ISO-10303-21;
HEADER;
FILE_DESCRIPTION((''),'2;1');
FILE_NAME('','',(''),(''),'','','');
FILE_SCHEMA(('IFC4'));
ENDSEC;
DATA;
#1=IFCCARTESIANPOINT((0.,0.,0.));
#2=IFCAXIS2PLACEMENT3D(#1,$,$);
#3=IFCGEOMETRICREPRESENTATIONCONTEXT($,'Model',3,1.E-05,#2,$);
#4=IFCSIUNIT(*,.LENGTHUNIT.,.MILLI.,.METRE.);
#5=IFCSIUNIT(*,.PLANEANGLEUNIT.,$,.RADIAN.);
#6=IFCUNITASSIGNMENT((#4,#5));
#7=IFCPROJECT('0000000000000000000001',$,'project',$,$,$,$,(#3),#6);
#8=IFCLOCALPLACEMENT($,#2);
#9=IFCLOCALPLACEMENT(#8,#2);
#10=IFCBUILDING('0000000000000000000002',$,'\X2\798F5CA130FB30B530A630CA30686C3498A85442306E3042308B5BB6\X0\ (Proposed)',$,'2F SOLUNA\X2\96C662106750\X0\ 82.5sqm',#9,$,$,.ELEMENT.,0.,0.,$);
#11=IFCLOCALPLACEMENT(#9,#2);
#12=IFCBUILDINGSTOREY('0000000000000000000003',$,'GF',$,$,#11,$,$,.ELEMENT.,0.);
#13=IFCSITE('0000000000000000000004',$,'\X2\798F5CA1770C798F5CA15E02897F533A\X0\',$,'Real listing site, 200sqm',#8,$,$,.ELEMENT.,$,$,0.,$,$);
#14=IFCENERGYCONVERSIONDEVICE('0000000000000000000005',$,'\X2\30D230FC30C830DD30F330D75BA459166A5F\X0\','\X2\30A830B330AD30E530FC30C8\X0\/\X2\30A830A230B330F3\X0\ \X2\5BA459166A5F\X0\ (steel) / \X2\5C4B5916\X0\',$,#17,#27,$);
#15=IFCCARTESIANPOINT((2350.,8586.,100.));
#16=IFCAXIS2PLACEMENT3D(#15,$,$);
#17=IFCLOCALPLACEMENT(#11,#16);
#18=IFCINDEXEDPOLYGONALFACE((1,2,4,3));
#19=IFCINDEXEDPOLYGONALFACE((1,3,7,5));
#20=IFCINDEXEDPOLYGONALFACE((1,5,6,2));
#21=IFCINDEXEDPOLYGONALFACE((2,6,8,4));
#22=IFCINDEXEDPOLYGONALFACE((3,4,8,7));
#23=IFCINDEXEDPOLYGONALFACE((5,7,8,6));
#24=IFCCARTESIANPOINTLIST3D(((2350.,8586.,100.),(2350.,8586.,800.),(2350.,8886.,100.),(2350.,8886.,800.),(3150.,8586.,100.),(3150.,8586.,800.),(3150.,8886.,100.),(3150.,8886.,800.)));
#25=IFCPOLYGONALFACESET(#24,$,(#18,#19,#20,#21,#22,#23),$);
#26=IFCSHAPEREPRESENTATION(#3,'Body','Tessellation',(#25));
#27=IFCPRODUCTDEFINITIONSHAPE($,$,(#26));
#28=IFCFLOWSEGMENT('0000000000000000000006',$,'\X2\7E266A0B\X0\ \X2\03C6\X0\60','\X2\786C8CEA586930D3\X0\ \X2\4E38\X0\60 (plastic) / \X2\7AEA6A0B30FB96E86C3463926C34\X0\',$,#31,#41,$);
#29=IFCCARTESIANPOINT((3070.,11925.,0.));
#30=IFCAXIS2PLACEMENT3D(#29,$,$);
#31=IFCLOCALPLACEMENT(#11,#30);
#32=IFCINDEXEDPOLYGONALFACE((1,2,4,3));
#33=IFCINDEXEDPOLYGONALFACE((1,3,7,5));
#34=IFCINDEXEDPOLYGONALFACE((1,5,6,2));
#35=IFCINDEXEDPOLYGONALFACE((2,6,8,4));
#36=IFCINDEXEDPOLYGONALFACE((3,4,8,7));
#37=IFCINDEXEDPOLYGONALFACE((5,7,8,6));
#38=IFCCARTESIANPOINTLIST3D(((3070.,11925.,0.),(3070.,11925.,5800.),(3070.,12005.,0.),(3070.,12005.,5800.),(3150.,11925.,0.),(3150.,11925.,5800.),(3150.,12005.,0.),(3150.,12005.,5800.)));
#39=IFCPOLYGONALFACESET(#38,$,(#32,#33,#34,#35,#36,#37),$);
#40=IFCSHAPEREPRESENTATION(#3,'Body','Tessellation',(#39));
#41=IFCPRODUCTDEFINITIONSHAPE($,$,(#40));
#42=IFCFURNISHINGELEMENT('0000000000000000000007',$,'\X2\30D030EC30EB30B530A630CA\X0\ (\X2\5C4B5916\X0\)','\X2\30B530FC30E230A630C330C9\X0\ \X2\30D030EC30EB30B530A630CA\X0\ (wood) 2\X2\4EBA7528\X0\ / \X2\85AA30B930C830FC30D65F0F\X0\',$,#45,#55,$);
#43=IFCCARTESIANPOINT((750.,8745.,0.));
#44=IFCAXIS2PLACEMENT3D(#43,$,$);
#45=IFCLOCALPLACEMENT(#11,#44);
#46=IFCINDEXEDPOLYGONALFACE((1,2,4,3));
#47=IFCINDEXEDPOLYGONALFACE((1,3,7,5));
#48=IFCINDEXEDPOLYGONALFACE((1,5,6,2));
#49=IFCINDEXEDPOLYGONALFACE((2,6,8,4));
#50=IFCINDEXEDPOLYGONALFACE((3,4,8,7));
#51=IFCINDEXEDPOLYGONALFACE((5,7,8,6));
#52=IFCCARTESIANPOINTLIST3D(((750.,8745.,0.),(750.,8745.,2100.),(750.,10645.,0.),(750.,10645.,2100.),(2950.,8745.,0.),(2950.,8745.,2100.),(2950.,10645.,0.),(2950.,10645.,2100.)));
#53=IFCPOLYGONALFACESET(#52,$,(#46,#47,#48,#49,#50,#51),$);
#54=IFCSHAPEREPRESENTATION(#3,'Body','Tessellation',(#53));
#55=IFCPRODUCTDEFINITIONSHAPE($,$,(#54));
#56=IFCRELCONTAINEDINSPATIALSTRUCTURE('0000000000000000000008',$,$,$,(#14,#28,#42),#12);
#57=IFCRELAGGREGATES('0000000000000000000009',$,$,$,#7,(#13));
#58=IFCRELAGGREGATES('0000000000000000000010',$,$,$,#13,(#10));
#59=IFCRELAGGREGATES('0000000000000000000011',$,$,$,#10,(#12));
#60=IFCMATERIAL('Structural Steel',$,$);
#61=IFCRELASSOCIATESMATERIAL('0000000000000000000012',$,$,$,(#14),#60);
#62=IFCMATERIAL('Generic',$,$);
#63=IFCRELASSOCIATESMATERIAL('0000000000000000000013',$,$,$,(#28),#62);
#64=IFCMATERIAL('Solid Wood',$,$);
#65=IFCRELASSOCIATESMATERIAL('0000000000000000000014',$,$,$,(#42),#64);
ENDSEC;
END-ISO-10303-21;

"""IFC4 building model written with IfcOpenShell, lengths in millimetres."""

from ifc_helpers import new_model, si_unit, frame, frame_2d, origin, place, context, project, spatial, rectangle, extrude, material, element, save


model = new_model("IFC4")

# Units and contexts
model_context = context("Model", 3, precision=1e-05, world=origin())
ifc_project = project(units=[si_unit("LENGTHUNIT", "METRE", prefix="MILLI"), si_unit("PLANEANGLEUNIT", "RADIAN")], contexts=[model_context])

# Site, building, storey
site_placement = place(None, origin())
site = spatial("IfcSite", under=ifc_project, at=site_placement, Name="福岡県福岡市西区", ObjectType="Real listing site, 200sqm", CompositionType="ELEMENT", RefElevation=0.0)
building_placement = place(site_placement, origin())
building = spatial("IfcBuilding", under=site, at=building_placement, Name="福岡・サウナと水風呂のある家 (Proposed)", ObjectType="2F SOLUNA集成材 82.5sqm", CompositionType="ELEMENT", ElevationOfRefHeight=0.0, ElevationOfTerrain=0.0)
storey_placement = place(building_placement, origin())
storey = spatial("IfcBuildingStorey", under=building, at=storey_placement, Name="GF", CompositionType="ELEMENT", Elevation=0.0)

# Shared definitions
ifc_material_1 = material(Name="Solid Wood")

# Shared definitions
ifc_material_2 = material(Name="Generic")

# Energy conversion device
ifc_material_3 = material(Name="Structural Steel")
energy_conversion_device_placement = place(storey_placement, frame((2350.0, 8586.0, 100.0)))
element("IfcEnergyConversionDevice", 1, at=energy_conversion_device_placement, inside=storey, material=ifc_material_3, Name="ヒートポンプ室外機", Description="エコキュート/エアコン 室外機 (steel) / 屋外", context=model_context, shape_type="SweptSolid", body=[
    extrude(rectangle(XDim=800.0, YDim=300.0, at=frame_2d((400.0, 150.0))), frame((2350.0, 8586.0, 100.0)), (0.0, 0.0, 1.0), 700.0),
])

# Flow segment
flow_segment_placement = place(storey_placement, frame((3070.0, 11925.0, 0.0)))
element("IfcFlowSegment", 2, at=flow_segment_placement, inside=storey, material=ifc_material_2, Name="縦樋 φ60", Description="硬質塩ビ 丸60 (plastic) / 竪樋・雨水排水", context=model_context, shape_type="SweptSolid", body=[
    extrude(rectangle(XDim=80.0, YDim=80.0, at=frame_2d((40.0, 40.0))), frame((3070.0, 11925.0, 0.0)), (0.0, 0.0, 1.0), 5800.0),
])

# Furnishing element
furnishing_placement = place(storey_placement, frame((750.0, 8745.0, 0.0)))
element("IfcFurnishingElement", 3, at=furnishing_placement, inside=storey, material=ifc_material_1, Name="バレルサウナ (屋外)", Description="サーモウッド バレルサウナ (wood) 2人用 / 薪ストーブ式", context=model_context, shape_type="SweptSolid", body=[
    extrude(rectangle(XDim=2200.0, YDim=1900.0, at=frame_2d((1100.0, 950.0))), frame((750.0, 8745.0, 0.0)), (0.0, 0.0, 1.0), 2100.0),
])

save(model, "model.ifc")
